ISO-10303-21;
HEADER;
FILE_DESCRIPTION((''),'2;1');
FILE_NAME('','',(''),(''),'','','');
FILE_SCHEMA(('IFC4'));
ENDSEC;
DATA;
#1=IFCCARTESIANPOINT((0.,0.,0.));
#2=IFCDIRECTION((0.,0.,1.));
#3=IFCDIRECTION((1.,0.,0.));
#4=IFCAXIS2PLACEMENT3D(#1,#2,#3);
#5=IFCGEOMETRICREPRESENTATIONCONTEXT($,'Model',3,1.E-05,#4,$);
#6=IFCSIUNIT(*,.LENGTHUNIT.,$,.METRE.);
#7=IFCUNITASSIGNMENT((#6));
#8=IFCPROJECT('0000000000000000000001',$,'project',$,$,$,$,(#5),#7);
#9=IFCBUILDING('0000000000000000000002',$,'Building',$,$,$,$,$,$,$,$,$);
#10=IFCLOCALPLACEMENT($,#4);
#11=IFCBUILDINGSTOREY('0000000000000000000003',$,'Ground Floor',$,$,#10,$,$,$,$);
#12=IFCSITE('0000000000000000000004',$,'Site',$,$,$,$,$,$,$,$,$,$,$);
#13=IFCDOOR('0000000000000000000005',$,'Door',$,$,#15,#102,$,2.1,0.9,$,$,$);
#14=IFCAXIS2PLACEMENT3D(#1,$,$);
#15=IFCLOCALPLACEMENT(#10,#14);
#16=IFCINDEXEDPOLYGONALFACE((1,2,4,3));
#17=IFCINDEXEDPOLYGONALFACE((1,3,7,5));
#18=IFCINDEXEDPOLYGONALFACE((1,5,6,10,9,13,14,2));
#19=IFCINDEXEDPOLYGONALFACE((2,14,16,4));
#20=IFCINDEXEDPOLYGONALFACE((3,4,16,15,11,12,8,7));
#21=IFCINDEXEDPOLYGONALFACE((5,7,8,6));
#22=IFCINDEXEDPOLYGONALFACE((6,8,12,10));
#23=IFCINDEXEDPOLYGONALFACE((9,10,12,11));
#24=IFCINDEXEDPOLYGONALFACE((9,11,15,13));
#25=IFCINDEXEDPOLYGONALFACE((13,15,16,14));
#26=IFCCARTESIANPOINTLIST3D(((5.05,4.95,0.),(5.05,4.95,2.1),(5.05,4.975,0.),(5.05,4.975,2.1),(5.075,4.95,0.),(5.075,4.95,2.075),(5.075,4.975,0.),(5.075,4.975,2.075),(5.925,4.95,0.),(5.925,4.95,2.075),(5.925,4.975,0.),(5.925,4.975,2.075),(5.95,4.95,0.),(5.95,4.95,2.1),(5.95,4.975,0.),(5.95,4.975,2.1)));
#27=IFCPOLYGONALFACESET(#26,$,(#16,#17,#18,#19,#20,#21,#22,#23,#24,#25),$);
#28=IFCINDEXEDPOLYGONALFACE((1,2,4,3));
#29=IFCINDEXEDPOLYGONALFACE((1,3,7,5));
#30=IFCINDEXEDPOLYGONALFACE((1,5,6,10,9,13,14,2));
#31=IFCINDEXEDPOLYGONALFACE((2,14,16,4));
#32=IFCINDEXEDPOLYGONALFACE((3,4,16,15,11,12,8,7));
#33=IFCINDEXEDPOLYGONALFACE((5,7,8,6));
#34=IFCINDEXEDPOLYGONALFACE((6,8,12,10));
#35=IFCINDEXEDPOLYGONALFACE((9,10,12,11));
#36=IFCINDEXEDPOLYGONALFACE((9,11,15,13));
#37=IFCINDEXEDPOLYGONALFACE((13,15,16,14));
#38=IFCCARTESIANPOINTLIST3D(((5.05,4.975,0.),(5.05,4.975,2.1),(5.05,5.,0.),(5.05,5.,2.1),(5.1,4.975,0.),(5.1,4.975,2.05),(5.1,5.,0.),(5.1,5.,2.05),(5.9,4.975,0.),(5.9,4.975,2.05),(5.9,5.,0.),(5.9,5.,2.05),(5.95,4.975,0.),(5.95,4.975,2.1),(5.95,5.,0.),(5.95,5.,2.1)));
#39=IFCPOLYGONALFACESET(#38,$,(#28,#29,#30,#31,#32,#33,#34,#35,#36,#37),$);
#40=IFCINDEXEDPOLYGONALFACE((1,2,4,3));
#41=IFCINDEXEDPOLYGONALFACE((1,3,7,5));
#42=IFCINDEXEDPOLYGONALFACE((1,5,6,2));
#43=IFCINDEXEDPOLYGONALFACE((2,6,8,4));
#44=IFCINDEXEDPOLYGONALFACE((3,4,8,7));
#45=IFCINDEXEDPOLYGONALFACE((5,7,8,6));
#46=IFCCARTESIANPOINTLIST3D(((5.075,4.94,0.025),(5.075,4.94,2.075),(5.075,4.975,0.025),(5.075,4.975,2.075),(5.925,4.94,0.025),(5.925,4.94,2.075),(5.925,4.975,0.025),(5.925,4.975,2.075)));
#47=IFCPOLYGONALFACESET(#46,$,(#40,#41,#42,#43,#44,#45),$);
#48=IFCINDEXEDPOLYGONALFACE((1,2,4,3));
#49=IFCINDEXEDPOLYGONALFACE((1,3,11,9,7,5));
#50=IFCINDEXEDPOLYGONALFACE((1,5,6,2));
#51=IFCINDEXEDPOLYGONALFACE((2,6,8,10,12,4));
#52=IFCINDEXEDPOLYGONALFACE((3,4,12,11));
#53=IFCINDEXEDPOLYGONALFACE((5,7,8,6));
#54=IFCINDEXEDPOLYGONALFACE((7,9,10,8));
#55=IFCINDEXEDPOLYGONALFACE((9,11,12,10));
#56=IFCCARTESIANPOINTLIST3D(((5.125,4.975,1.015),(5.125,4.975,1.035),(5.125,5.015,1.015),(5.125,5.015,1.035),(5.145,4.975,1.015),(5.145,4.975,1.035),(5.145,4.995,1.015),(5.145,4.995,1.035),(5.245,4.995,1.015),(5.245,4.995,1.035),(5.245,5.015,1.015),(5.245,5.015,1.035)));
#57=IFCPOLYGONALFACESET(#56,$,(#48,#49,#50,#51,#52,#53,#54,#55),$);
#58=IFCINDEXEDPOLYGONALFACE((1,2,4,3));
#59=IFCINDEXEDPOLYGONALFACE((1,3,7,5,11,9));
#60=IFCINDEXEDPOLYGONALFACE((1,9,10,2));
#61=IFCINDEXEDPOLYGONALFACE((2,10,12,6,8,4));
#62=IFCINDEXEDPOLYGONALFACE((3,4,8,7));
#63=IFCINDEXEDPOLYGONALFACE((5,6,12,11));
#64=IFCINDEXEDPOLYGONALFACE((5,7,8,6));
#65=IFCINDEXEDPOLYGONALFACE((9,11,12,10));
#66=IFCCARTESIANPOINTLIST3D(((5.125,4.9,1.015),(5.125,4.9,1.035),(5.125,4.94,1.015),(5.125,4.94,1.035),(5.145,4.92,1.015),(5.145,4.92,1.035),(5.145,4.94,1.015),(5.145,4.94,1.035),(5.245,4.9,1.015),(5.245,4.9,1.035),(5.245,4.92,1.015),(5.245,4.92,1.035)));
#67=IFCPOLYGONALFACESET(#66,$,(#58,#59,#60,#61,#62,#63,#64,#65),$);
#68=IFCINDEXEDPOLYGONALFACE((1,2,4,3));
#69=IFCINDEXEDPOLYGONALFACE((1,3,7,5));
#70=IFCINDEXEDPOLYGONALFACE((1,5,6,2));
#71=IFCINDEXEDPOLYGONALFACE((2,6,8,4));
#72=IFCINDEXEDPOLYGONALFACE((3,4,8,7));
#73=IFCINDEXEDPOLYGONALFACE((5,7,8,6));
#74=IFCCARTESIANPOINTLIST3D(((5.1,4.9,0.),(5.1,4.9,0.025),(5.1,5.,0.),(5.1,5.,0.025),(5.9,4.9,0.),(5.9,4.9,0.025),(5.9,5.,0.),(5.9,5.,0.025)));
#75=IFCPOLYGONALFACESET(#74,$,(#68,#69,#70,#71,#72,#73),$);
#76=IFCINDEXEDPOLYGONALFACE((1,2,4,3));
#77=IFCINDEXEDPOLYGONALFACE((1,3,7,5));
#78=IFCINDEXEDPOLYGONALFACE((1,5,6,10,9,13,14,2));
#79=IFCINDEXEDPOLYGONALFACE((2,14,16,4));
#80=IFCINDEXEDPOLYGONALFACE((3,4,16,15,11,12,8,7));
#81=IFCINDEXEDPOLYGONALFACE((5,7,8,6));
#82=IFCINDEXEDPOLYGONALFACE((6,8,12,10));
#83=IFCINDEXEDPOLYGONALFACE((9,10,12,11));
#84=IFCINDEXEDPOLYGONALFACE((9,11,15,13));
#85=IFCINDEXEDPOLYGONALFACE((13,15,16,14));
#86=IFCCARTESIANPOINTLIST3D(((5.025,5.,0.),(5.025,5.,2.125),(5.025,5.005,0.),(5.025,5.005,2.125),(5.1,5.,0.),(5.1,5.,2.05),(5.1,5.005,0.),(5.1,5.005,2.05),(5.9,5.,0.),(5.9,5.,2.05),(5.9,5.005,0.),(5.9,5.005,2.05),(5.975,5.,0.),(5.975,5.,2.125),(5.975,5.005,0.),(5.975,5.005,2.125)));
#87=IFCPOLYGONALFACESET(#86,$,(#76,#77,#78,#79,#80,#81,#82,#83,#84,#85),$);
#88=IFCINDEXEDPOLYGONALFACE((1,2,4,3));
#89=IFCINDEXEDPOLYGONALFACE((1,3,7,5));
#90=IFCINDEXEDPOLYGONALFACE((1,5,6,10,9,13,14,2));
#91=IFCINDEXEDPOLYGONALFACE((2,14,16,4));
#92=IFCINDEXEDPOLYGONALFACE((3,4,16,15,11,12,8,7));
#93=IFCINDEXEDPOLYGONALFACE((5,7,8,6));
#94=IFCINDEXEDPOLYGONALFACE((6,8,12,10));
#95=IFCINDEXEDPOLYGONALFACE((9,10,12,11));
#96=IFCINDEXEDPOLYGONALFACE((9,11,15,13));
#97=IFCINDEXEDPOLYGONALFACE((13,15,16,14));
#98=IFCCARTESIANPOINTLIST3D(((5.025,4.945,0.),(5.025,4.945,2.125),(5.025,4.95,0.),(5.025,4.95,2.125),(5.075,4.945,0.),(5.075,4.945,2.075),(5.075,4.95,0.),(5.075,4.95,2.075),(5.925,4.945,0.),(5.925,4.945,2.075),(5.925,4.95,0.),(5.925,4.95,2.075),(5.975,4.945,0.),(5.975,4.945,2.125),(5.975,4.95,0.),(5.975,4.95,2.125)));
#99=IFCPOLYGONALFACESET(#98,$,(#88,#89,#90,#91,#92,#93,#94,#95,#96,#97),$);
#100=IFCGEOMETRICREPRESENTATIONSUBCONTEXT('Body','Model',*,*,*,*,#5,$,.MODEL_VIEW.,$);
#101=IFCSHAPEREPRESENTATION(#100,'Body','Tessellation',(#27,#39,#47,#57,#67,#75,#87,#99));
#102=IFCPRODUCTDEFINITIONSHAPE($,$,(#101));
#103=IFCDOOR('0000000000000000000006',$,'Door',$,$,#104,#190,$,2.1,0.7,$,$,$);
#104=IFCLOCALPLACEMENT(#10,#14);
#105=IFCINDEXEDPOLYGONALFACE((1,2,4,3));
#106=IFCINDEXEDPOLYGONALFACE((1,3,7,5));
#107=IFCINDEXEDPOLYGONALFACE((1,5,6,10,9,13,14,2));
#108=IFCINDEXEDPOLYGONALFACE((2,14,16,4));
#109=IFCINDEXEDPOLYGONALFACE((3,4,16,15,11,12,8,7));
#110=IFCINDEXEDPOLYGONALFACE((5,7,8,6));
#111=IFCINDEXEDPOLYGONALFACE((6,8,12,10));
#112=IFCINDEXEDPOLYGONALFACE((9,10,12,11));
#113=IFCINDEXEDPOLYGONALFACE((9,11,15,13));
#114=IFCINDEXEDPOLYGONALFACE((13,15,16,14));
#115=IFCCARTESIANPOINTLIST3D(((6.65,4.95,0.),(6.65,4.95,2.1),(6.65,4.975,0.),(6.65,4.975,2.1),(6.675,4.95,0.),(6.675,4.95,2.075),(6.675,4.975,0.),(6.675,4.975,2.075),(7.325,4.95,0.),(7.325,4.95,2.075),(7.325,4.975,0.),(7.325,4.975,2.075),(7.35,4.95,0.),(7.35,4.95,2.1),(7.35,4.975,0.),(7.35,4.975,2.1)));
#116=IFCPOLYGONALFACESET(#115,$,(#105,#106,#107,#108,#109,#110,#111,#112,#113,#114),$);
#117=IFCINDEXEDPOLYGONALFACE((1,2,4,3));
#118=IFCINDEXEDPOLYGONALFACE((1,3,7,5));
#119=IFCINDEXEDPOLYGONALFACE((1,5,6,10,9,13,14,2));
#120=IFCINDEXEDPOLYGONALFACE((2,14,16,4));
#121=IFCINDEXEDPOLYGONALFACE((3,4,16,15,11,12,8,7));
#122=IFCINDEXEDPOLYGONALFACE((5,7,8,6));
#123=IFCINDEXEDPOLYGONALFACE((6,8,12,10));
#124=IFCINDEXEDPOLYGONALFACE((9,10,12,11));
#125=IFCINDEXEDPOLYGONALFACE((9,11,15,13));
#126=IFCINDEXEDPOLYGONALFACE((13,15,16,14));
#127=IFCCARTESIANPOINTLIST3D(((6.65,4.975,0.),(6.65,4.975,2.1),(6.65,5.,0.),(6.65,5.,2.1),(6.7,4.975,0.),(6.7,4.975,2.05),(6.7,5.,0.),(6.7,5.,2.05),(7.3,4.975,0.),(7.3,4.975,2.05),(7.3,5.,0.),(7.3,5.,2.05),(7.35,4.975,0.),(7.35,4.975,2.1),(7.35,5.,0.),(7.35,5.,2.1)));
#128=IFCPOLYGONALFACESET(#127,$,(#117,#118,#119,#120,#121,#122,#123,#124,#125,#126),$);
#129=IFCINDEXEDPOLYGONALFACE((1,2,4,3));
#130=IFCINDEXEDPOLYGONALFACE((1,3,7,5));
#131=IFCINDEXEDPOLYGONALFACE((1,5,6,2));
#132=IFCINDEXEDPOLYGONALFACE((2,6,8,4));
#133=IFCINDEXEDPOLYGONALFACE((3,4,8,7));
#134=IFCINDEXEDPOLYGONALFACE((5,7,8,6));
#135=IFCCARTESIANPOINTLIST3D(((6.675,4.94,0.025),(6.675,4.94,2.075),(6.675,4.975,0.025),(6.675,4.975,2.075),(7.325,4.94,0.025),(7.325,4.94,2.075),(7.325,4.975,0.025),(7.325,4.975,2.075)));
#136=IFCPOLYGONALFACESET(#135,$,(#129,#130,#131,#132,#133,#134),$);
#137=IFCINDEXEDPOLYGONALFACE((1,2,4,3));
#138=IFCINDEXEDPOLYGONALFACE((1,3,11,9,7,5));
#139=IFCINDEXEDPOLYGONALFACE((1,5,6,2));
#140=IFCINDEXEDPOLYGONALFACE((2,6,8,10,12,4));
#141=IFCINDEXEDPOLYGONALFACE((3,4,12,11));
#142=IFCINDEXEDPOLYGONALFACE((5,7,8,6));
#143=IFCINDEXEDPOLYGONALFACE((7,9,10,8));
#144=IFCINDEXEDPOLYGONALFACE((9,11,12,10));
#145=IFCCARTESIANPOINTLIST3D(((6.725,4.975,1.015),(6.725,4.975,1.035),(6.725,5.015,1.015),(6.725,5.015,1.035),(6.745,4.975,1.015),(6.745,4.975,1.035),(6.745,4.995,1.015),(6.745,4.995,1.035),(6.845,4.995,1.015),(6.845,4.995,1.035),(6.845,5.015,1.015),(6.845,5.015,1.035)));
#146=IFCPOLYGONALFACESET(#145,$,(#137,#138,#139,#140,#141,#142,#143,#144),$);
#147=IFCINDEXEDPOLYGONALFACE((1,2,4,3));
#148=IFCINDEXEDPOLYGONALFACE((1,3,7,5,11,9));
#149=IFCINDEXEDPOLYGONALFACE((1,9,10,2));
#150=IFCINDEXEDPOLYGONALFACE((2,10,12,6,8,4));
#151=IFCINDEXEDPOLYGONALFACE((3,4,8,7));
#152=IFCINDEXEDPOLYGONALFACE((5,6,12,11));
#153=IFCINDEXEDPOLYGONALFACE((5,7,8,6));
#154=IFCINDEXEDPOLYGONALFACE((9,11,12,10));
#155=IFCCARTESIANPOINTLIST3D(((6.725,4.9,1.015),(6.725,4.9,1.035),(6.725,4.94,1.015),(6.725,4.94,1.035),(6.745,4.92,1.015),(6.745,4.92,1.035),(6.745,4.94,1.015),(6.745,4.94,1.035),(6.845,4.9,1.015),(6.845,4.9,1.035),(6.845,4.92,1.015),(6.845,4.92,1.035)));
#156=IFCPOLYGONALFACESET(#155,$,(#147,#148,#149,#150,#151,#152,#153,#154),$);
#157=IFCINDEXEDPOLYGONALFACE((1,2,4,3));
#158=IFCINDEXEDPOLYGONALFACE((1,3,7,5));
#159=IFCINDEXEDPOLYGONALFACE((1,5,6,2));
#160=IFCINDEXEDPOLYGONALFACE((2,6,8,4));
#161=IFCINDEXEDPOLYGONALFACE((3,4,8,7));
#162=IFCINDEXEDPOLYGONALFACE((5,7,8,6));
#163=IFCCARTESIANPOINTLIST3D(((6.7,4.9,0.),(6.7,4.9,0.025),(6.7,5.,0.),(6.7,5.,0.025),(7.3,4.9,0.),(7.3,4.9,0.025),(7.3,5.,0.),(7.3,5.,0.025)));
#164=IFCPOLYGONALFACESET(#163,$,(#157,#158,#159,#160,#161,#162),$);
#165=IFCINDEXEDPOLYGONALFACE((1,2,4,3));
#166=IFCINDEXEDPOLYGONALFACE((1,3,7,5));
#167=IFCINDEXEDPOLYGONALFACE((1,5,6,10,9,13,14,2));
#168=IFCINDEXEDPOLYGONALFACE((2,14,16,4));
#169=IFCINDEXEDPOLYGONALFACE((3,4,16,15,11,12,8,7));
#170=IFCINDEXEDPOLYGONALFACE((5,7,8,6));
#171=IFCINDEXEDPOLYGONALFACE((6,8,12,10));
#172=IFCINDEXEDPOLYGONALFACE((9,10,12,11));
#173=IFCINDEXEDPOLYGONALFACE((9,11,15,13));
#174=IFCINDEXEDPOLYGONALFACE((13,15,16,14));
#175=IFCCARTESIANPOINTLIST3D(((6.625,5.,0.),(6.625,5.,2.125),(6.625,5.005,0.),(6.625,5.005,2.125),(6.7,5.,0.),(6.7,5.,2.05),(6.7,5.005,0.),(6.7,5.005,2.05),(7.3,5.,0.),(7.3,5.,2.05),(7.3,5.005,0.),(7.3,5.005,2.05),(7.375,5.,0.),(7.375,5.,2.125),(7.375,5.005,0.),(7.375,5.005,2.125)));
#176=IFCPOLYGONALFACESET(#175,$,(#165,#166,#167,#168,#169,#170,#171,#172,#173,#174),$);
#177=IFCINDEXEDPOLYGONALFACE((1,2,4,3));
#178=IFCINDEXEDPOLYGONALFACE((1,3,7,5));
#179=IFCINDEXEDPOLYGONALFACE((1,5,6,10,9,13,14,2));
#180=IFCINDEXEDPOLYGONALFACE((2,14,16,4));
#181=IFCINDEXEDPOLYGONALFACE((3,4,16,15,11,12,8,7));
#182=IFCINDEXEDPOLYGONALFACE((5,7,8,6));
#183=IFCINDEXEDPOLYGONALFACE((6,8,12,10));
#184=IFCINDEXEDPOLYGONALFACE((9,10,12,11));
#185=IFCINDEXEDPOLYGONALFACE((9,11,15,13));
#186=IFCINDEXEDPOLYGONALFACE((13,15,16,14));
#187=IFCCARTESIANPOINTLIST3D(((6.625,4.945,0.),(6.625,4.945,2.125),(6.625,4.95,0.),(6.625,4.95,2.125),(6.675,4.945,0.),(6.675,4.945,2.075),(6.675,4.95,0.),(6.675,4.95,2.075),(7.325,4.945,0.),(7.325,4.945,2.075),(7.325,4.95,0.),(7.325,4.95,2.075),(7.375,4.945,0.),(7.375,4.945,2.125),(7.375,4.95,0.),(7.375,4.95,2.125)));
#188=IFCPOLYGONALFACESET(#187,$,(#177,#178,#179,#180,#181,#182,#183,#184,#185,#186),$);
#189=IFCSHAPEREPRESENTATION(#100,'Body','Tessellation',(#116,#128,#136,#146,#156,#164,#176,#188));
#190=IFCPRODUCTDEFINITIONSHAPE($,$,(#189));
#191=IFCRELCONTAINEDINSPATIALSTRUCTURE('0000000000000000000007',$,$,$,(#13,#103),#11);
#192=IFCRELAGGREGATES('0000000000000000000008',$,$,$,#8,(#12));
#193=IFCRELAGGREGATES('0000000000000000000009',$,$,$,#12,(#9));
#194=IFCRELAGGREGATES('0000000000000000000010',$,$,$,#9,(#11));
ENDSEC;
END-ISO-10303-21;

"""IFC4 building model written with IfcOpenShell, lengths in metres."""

from ifc_helpers import new_model, si_unit, frame, origin_with_axes, place, context, subcontext, project, spatial, line, indexed_curve, outline, extrude, element, save


model = new_model("IFC4")

# Units and contexts
model_context = context("Model", 3, precision=1e-05, world=origin_with_axes())
body_context = subcontext(model_context, "Body", "Model", "MODEL_VIEW")
ifc_project = project(units=[si_unit("LENGTHUNIT", "METRE")], contexts=[model_context])

# Site, building, storey
site = spatial("IfcSite", under=ifc_project, Name="Site")
building = spatial("IfcBuilding", under=site, Name="Building")
storey_placement = place(None, origin_with_axes())
storey = spatial("IfcBuildingStorey", under=building, at=storey_placement, Name="Ground Floor")

# Doors
door_1_placement = place(storey_placement, frame((5.95, 5.0, 0.0), z_axis=(0.0, 0.0, 1.0), x_axis=(-1.0, 0.0, 0.0)))
element("IfcDoor", 1, at=door_1_placement, inside=storey, Name="Door", OverallHeight=2.1, OverallWidth=0.9, context=body_context, shape_type="SweptSolid", body=[
    extrude(outline(indexed_curve([(0.0, 0.0), (0.0, 2.1), (0.9, 2.1), (0.9, 0.0), (0.875, 0.0), (0.875, 2.075), (0.025, 2.075), (0.025, 0.0)], segments=[line(1, 2, 3, 4, 5, 6, 7, 8, 1)])), frame((0.0, 0.025, 0.0), z_axis=(0.0, -1.0, 0.0), x_axis=(1.0, 0.0, 0.0)), (0.0, 0.0, -1.0), 0.025),
    extrude(outline(indexed_curve([(0.0, 0.0), (0.0, 2.1), (0.9, 2.1), (0.9, 0.0), (0.85, 0.0), (0.85, 2.05), (0.05, 2.05), (0.05, 0.0)], segments=[line(1, 2, 3, 4, 5, 6, 7, 8, 1)])), frame((0.0, 0.0, 0.0), z_axis=(0.0, -1.0, 0.0), x_axis=(1.0, 0.0, 0.0)), (0.0, 0.0, -1.0), 0.025),
    extrude(outline(indexed_curve([(0.0, 0.0), (0.85, 0.0), (0.85, 0.035), (0.0, 0.035)], segments=[line(1, 2, 3, 4, 1)])), frame((0.025, 0.025, 0.025), z_axis=(0.0, 0.0, 1.0), x_axis=(1.0, 0.0, 0.0)), (0.0, 0.0, 1.0), 2.05),
    extrude(outline(indexed_curve([(0.0, 0.0), (0.0, -0.04), (-0.12, -0.04), (-0.12, -0.02), (-0.02, -0.02), (-0.02, 0.0)], segments=[line(1, 2, 3, 4, 5, 6, 1)])), frame((0.825, 0.025, 1.015), z_axis=(0.0, 0.0, 1.0), x_axis=(1.0, 0.0, 0.0)), (0.0, 0.0, 1.0), 0.02),
    extrude(outline(indexed_curve([(0.0, 0.0), (0.0, 0.04), (-0.12, 0.04), (-0.12, 0.02), (-0.02, 0.02), (-0.02, 0.0)], segments=[line(1, 2, 3, 4, 5, 6, 1)])), frame((0.825, 0.06, 1.015), z_axis=(0.0, 0.0, 1.0), x_axis=(1.0, 0.0, 0.0)), (0.0, 0.0, 1.0), 0.02),
    extrude(outline(indexed_curve([(0.0, 0.0), (0.8, 0.0), (0.8, 0.1), (0.0, 0.1)], segments=[line(1, 2, 3, 4, 1)])), frame((0.05, 0.0, 0.0), z_axis=(0.0, 0.0, 1.0), x_axis=(1.0, 0.0, 0.0)), (0.0, 0.0, 1.0), 0.025),
    extrude(outline(indexed_curve([(0.0, 0.0), (0.0, 2.125), (0.95, 2.125), (0.95, 0.0), (0.875, 0.0), (0.875, 2.05), (0.075, 2.05), (0.075, 0.0)], segments=[line(1, 2, 3, 4, 5, 6, 7, 8, 1)])), frame((-0.025, -0.005, 0.0), z_axis=(0.0, -1.0, 0.0), x_axis=(1.0, 0.0, 0.0)), (0.0, 0.0, -1.0), 0.005),
    extrude(outline(indexed_curve([(0.0, 0.0), (0.0, 2.125), (0.95, 2.125), (0.95, 0.0), (0.9, 0.0), (0.9, 2.075), (0.05, 2.075), (0.05, 0.0)], segments=[line(1, 2, 3, 4, 5, 6, 7, 8, 1)])), frame((-0.025, 0.05, 0.0), z_axis=(0.0, -1.0, 0.0), x_axis=(1.0, 0.0, 0.0)), (0.0, 0.0, -1.0), 0.005),
])
door_2_placement = place(storey_placement, frame((7.35, 5.0, 0.0), z_axis=(0.0, 0.0, 1.0), x_axis=(-1.0, 0.0, 0.0)))
element("IfcDoor", 2, at=door_2_placement, inside=storey, Name="Door", OverallHeight=2.1, OverallWidth=0.7, context=body_context, shape_type="SweptSolid", body=[
    extrude(outline(indexed_curve([(0.0, 0.0), (0.0, 2.1), (0.7, 2.1), (0.7, 0.0), (0.675, 0.0), (0.675, 2.075), (0.025, 2.075), (0.025, 0.0)], segments=[line(1, 2, 3, 4, 5, 6, 7, 8, 1)])), frame((0.0, 0.025, 0.0), z_axis=(0.0, -1.0, 0.0), x_axis=(1.0, 0.0, 0.0)), (0.0, 0.0, -1.0), 0.025),
    extrude(outline(indexed_curve([(0.0, 0.0), (0.0, 2.1), (0.7, 2.1), (0.7, 0.0), (0.65, 0.0), (0.65, 2.05), (0.05, 2.05), (0.05, 0.0)], segments=[line(1, 2, 3, 4, 5, 6, 7, 8, 1)])), frame((0.0, 0.0, 0.0), z_axis=(0.0, -1.0, 0.0), x_axis=(1.0, 0.0, 0.0)), (0.0, 0.0, -1.0), 0.025),
    extrude(outline(indexed_curve([(0.0, 0.0), (0.65, 0.0), (0.65, 0.035), (0.0, 0.035)], segments=[line(1, 2, 3, 4, 1)])), frame((0.025, 0.025, 0.025), z_axis=(0.0, 0.0, 1.0), x_axis=(1.0, 0.0, 0.0)), (0.0, 0.0, 1.0), 2.05),
    extrude(outline(indexed_curve([(0.0, 0.0), (0.0, -0.04), (-0.12, -0.04), (-0.12, -0.02), (-0.02, -0.02), (-0.02, 0.0)], segments=[line(1, 2, 3, 4, 5, 6, 1)])), frame((0.625, 0.025, 1.015), z_axis=(0.0, 0.0, 1.0), x_axis=(1.0, 0.0, 0.0)), (0.0, 0.0, 1.0), 0.02),
    extrude(outline(indexed_curve([(0.0, 0.0), (0.0, 0.04), (-0.12, 0.04), (-0.12, 0.02), (-0.02, 0.02), (-0.02, 0.0)], segments=[line(1, 2, 3, 4, 5, 6, 1)])), frame((0.625, 0.06, 1.015), z_axis=(0.0, 0.0, 1.0), x_axis=(1.0, 0.0, 0.0)), (0.0, 0.0, 1.0), 0.02),
    extrude(outline(indexed_curve([(0.0, 0.0), (0.6, 0.0), (0.6, 0.1), (0.0, 0.1)], segments=[line(1, 2, 3, 4, 1)])), frame((0.05, 0.0, 0.0), z_axis=(0.0, 0.0, 1.0), x_axis=(1.0, 0.0, 0.0)), (0.0, 0.0, 1.0), 0.025),
    extrude(outline(indexed_curve([(0.0, 0.0), (0.0, 2.125), (0.75, 2.125), (0.75, 0.0), (0.675, 0.0), (0.675, 2.05), (0.075, 2.05), (0.075, 0.0)], segments=[line(1, 2, 3, 4, 5, 6, 7, 8, 1)])), frame((-0.025, -0.005, 0.0), z_axis=(0.0, -1.0, 0.0), x_axis=(1.0, 0.0, 0.0)), (0.0, 0.0, -1.0), 0.005),
    extrude(outline(indexed_curve([(0.0, 0.0), (0.0, 2.125), (0.75, 2.125), (0.75, 0.0), (0.7, 0.0), (0.7, 2.075), (0.05, 2.075), (0.05, 0.0)], segments=[line(1, 2, 3, 4, 5, 6, 7, 8, 1)])), frame((-0.025, 0.05, 0.0), z_axis=(0.0, -1.0, 0.0), x_axis=(1.0, 0.0, 0.0)), (0.0, 0.0, -1.0), 0.005),
])

save(model, "model.ifc")
